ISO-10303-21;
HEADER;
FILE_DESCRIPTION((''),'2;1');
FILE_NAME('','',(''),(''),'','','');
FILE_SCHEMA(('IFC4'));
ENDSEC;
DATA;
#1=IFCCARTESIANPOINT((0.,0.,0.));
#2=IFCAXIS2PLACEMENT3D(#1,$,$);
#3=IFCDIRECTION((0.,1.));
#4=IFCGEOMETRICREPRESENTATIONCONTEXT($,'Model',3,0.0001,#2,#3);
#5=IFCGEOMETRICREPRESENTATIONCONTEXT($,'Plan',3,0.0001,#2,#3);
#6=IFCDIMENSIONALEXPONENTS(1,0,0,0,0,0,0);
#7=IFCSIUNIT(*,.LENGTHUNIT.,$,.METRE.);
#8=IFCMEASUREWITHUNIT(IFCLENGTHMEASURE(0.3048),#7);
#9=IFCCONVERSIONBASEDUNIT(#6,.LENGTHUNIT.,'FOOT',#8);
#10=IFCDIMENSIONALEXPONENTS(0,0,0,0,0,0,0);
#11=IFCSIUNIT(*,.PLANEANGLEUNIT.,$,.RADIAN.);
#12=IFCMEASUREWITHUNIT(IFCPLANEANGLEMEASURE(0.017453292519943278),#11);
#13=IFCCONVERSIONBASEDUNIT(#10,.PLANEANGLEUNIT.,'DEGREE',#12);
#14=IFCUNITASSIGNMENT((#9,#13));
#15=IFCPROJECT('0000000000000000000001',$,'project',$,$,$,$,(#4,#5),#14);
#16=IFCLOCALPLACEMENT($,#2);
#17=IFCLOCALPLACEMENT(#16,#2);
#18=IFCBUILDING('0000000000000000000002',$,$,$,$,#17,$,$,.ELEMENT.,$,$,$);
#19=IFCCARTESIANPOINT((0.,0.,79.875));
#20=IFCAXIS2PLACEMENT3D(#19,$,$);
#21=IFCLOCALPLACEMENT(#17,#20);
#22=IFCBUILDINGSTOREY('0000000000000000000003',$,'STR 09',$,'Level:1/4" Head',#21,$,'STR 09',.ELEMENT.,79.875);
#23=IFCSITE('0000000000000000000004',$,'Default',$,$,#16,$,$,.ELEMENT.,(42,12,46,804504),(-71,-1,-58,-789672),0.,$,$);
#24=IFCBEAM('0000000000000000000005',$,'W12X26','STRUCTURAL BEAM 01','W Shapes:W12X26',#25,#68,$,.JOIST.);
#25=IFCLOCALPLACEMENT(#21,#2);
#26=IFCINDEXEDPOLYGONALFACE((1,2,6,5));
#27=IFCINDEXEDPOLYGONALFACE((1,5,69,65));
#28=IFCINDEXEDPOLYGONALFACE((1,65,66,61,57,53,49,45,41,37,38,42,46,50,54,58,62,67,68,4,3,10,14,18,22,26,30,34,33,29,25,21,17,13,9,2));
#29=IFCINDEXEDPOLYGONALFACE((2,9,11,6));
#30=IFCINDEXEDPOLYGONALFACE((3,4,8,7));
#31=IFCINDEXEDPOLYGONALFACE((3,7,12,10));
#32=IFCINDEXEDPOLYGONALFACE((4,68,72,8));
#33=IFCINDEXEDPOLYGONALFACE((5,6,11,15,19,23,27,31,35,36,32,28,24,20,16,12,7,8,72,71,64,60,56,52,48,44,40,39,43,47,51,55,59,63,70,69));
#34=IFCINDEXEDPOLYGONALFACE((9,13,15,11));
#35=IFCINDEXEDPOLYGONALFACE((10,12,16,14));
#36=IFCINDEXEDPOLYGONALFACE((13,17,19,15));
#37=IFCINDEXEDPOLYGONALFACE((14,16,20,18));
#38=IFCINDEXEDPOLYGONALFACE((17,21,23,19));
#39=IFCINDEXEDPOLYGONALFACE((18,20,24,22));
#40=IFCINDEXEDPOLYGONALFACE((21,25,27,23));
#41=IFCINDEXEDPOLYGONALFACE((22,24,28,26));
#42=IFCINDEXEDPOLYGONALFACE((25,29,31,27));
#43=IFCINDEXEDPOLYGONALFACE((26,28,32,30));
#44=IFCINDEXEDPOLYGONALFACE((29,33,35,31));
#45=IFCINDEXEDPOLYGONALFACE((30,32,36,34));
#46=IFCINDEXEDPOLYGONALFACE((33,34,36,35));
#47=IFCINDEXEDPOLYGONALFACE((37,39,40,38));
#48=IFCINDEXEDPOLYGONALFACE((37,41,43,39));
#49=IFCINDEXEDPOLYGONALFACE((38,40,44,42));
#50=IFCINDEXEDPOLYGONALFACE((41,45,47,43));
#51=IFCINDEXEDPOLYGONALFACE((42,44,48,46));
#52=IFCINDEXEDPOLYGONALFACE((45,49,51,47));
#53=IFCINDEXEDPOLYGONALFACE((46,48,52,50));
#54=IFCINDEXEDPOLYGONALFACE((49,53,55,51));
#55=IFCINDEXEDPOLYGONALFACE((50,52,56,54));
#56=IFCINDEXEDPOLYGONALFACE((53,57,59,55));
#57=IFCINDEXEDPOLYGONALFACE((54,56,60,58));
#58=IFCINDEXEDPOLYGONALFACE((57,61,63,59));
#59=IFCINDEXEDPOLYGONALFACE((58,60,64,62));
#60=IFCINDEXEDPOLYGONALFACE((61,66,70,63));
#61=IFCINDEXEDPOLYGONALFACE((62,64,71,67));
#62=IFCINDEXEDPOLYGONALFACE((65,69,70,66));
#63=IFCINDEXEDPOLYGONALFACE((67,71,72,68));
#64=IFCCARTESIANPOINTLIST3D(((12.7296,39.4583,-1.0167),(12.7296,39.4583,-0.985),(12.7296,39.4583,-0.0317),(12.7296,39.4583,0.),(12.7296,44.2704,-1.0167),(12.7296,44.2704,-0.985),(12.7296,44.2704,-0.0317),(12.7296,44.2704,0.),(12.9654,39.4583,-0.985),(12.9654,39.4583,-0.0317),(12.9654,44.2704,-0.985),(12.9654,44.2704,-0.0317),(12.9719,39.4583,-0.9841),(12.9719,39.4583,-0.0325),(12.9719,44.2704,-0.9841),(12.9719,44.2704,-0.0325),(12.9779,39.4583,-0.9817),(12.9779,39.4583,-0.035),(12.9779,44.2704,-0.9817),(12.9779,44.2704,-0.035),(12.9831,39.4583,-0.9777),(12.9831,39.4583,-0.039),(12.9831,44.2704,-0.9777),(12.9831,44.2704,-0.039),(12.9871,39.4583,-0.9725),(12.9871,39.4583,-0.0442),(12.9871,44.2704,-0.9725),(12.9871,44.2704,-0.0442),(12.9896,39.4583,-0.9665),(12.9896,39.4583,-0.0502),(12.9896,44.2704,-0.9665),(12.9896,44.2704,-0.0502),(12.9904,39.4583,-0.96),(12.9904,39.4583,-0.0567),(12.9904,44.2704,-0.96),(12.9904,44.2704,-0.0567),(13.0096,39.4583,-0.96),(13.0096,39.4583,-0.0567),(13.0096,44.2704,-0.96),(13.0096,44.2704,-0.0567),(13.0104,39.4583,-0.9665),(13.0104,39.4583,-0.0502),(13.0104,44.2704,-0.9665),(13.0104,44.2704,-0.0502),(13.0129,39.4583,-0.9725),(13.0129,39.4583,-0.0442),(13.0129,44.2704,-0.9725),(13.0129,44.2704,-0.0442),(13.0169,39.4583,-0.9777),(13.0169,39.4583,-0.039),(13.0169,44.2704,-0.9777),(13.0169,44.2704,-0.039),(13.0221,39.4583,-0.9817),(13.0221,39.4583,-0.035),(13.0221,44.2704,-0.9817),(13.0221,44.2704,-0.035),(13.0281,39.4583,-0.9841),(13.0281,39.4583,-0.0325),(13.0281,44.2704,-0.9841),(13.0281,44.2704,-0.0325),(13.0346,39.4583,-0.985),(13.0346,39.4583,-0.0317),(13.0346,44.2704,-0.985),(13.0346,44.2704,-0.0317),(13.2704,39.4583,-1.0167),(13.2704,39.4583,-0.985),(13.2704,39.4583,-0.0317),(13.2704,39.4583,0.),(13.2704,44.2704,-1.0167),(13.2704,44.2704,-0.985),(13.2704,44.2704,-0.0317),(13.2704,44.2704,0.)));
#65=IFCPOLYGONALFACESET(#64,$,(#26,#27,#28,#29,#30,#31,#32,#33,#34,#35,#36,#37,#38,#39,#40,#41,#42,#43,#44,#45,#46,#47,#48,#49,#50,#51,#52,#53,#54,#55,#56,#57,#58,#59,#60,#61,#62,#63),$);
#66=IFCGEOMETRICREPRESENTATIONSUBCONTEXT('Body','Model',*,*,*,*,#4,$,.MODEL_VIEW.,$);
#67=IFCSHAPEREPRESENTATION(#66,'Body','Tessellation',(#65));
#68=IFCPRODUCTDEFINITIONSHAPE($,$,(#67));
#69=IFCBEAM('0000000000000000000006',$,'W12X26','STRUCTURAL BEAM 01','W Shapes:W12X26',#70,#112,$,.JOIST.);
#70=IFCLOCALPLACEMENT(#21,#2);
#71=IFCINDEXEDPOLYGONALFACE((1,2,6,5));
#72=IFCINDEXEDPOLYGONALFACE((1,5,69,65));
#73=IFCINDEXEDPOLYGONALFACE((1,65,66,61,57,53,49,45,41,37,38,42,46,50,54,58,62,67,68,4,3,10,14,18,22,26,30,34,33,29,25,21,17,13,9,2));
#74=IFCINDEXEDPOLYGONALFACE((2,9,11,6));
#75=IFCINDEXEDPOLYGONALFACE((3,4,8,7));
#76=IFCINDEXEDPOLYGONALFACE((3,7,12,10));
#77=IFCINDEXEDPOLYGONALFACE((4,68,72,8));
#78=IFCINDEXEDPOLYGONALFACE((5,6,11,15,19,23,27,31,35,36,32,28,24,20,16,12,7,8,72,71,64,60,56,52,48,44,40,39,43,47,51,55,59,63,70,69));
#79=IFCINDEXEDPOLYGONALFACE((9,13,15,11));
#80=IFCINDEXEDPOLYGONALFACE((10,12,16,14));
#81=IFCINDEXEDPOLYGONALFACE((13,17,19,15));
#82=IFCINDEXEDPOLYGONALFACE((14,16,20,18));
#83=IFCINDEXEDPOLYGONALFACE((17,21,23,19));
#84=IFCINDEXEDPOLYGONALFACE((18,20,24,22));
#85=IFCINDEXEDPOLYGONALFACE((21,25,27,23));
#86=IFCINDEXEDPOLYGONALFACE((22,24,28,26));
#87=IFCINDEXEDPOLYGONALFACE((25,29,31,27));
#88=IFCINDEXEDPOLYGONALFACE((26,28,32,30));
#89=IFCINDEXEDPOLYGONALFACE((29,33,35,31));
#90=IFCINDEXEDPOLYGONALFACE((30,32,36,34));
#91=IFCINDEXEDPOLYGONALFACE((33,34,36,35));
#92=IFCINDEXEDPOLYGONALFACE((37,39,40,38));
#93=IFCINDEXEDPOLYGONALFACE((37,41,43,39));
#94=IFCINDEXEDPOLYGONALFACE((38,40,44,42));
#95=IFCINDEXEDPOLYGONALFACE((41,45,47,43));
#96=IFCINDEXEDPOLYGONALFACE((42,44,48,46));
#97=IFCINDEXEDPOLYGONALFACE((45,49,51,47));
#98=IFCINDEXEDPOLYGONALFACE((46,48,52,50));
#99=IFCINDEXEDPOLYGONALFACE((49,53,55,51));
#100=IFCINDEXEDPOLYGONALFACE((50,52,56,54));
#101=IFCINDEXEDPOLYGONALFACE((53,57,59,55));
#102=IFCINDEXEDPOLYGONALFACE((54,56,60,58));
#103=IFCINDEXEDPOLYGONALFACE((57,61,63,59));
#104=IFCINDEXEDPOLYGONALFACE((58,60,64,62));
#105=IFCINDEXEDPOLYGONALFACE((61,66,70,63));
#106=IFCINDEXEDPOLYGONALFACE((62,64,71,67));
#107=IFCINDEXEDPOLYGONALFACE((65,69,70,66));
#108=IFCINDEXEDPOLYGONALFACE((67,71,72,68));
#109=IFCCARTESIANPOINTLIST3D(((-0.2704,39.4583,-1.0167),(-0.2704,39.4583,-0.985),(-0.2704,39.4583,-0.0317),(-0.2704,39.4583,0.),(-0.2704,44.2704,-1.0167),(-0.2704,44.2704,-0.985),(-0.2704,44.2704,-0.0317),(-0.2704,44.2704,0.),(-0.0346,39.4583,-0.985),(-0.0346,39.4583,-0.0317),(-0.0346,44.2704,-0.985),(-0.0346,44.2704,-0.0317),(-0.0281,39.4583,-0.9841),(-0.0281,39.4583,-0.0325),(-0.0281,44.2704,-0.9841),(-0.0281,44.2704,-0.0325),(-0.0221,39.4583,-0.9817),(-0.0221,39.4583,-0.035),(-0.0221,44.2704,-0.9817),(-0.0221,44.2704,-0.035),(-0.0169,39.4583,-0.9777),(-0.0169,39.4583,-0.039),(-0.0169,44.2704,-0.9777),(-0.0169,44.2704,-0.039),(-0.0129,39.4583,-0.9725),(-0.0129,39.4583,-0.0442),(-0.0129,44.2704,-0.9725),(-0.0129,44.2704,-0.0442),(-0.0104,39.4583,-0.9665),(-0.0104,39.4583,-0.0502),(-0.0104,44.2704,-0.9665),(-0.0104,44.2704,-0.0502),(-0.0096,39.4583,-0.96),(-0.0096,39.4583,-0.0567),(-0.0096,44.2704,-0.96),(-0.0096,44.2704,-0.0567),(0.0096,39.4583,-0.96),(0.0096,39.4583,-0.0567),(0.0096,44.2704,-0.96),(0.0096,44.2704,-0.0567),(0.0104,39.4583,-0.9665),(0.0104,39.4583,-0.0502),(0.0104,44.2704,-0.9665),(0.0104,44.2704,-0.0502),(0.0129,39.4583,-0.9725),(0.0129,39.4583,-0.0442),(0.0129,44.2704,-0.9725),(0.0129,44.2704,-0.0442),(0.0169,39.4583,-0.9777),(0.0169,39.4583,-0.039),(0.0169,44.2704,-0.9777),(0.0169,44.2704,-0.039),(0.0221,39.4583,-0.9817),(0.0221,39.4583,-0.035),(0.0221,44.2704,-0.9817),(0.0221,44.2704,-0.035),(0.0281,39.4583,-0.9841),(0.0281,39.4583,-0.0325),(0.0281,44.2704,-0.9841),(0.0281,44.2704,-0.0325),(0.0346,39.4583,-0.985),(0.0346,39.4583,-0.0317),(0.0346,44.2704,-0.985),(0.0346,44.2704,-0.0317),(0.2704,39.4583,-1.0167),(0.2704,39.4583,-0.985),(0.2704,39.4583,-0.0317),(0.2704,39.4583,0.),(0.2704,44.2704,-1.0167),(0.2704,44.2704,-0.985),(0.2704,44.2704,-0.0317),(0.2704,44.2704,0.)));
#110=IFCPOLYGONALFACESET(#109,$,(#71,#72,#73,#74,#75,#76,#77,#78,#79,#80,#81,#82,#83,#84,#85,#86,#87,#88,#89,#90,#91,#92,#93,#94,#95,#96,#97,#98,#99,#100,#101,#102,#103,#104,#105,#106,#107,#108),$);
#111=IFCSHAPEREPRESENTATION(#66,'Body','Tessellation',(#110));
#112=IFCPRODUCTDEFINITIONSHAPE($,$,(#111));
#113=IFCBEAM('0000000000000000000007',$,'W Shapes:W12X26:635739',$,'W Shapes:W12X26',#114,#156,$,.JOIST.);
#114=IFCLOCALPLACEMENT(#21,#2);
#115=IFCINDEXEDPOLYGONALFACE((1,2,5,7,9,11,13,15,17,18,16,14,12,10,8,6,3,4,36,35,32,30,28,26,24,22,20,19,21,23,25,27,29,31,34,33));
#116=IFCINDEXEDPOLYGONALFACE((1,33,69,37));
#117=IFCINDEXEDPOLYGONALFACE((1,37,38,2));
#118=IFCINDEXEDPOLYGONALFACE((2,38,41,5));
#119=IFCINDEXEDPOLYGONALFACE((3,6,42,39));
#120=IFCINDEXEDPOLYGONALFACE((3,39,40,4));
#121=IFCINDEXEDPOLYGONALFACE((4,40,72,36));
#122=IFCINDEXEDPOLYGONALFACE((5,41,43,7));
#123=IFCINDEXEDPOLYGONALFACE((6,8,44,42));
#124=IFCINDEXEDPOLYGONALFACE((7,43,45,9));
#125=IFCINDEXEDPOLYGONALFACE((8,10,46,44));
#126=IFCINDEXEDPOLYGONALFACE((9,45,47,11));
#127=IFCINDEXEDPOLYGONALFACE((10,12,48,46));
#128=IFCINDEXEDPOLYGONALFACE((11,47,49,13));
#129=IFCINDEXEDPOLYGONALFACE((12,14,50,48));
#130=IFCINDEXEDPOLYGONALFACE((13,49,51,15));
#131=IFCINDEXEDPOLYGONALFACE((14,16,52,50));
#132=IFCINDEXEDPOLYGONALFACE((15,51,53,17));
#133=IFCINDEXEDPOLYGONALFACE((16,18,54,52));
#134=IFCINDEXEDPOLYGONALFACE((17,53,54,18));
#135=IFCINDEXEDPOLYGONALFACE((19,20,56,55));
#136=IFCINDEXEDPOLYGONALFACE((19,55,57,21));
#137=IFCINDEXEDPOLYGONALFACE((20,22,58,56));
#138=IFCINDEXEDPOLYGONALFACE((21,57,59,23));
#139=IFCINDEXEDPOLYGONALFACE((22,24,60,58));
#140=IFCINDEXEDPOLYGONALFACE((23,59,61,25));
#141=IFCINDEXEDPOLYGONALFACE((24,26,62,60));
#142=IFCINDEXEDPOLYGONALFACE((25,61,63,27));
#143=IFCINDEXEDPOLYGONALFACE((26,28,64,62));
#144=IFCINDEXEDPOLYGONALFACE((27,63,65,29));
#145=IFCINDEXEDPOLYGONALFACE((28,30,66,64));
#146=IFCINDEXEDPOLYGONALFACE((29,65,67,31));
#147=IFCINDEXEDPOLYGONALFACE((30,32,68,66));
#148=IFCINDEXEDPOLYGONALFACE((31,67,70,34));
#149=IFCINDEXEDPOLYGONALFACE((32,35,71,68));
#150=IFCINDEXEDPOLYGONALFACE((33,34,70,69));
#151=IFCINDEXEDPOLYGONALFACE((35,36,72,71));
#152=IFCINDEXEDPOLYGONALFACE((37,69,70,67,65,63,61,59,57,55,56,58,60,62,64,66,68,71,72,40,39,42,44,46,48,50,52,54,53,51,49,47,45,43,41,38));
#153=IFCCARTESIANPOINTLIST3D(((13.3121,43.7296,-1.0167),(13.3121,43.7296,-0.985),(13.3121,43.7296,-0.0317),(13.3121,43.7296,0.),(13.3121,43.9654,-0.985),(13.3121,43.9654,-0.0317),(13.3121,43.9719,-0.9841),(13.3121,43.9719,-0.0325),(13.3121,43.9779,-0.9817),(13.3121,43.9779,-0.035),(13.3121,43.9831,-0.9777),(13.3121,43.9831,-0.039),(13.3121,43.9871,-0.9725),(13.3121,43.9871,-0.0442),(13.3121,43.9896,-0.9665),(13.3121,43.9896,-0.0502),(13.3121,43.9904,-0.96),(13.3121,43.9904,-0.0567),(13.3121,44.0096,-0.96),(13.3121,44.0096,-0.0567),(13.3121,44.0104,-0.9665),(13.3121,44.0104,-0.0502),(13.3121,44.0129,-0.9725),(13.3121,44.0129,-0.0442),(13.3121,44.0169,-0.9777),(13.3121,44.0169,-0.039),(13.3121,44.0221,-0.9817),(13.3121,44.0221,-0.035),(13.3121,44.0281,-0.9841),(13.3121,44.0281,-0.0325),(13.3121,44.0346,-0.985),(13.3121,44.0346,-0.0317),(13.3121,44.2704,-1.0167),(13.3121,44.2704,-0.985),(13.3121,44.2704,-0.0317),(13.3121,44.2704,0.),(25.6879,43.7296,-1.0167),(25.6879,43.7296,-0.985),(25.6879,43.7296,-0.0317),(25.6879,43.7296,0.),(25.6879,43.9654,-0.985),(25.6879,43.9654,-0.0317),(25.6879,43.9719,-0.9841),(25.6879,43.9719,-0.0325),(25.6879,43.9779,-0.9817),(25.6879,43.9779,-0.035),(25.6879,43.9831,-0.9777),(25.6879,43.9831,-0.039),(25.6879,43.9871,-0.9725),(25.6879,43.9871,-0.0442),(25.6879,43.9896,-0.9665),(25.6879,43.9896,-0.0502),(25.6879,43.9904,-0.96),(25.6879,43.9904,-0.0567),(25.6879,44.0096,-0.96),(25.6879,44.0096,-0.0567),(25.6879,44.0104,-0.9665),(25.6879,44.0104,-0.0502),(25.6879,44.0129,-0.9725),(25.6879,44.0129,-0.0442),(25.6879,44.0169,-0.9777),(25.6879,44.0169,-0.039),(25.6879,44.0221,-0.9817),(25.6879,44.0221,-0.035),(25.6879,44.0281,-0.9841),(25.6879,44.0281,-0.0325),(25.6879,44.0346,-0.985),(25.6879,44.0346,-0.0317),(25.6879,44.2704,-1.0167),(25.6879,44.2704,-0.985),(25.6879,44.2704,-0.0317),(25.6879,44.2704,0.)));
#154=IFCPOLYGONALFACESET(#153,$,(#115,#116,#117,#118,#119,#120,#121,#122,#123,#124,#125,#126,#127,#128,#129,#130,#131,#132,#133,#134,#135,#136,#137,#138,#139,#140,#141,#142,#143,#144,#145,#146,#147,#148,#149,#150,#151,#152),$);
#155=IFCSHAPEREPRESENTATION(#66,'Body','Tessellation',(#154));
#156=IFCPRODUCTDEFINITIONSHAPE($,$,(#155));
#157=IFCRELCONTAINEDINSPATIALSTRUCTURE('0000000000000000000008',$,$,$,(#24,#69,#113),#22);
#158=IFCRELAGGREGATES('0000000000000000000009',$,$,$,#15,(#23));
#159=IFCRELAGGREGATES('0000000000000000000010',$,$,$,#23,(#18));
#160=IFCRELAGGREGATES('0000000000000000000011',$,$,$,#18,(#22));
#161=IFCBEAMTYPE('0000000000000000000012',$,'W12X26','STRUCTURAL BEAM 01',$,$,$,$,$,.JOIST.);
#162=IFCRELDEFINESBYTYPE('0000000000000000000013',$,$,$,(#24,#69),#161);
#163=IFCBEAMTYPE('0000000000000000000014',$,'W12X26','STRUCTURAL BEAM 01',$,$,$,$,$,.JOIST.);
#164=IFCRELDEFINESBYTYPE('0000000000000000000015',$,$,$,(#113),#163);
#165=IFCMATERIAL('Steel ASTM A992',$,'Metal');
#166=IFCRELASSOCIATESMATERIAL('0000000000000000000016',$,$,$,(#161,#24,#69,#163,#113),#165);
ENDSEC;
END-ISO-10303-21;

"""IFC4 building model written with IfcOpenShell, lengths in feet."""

from ifc_helpers import new_model, entity, si_unit, converted_unit, direction, frame, origin, place, context, subcontext, project, spatial, line, arc, indexed_curve, outline, extrude, source, transform, mapped, material, type_object, type_shapes, element, save


model = new_model("IFC4")

# Units and contexts
model_context = context("Model", 3, precision=0.0001, world=origin(), true_north=direction((0.0, 1.0)))
plan_context = context("Plan", 3, precision=0.0001, world=origin(), true_north=direction((0.0, 1.0)))
body_context = subcontext(model_context, "Body", "Model", "MODEL_VIEW")
ifc_project = project(units=[converted_unit("LENGTHUNIT", "FOOT", entity("IfcLengthMeasure", 0.3048), si_unit("LENGTHUNIT", "METRE"), dimensions=[1, 0, 0, 0, 0, 0, 0]), converted_unit("PLANEANGLEUNIT", "DEGREE", entity("IfcPlaneAngleMeasure", 0.017453292519943278), si_unit("PLANEANGLEUNIT", "RADIAN"), dimensions=[0, 0, 0, 0, 0, 0, 0])], contexts=[model_context, plan_context])

# Site, building, storey
site_placement = place(None, origin())
site = spatial("IfcSite", under=ifc_project, at=site_placement, Name="Default", CompositionType="ELEMENT", RefLatitude=(42, 12, 46, 804504), RefLongitude=(-71, -1, -58, -789672), RefElevation=0.0)
building_placement = place(site_placement, origin())
building = spatial("IfcBuilding", under=site, at=building_placement, CompositionType="ELEMENT")
storey_placement = place(building_placement, frame((0.0, 0.0, 79.875)))
storey = spatial("IfcBuildingStorey", under=building, at=storey_placement, Name="STR 09", ObjectType="Level:1/4\" Head", LongName="STR 09", CompositionType="ELEMENT", Elevation=79.875)

# Beams
ifc_material = material(Name="Steel ASTM A992", Category="Metal")
beam_type_1 = type_object("IfcBeamType", Name="W12X26", Description="STRUCTURAL BEAM 01", PredefinedType="JOIST", material=ifc_material)
shared_shape_1 = source(origin(), body_context, "Body", "SweptSolid", [
    extrude(outline(indexed_curve([(0.4767, -0.2704), (0.5083, -0.2704), (0.5083, 0.2704), (0.4767, 0.2704), (0.4767, 0.0346), (0.4693, 0.0169), (0.4517, 0.0096), (-0.4517, 0.0096), (-0.4693, 0.0169), (-0.4767, 0.0346), (-0.4767, 0.2704), (-0.5083, 0.2704), (-0.5083, -0.2704), (-0.4767, -0.2704), (-0.4767, -0.0346), (-0.4693, -0.0169), (-0.4517, -0.0096), (0.4517, -0.0096), (0.4693, -0.0169), (0.4767, -0.0346)], segments=[line(1, 2, 3, 4, 5), arc(5, 6, 7), line(7, 8), arc(8, 9, 10), line(10, 11, 12, 13, 14, 15), arc(15, 16, 17), line(17, 18), arc(18, 19, 20), line(20, 1)], self_intersect=False)), frame((-2.7704, 0.0, 0.0), z_axis=(1.0, 0.0, 0.0), x_axis=(0.0, 0.0, -1.0)), (0.0, 0.0, 1.0), 4.8121),
])
type_shapes(beam_type_1, [shared_shape_1])
for number, where, z_axis, x_axis, name in (
    (1, (13.0, 41.5, -0.5083), (0.0, 0.0, 1.0), (0.0, -1.0, 0.0), "W12X26"),
    (2, (0.0, 41.5, -0.5083), (0.0, 0.0, 1.0), (0.0, -1.0, 0.0), "W12X26"),
):
    element("IfcBeam", number, at=place(storey_placement, frame(where, z_axis=z_axis, x_axis=x_axis)), inside=storey, type_object=beam_type_1, material=ifc_material, Name=name, Description="STRUCTURAL BEAM 01", ObjectType="W Shapes:W12X26", PredefinedType="JOIST", context=body_context, shape_type="MappedRepresentation", body=[
        mapped(shared_shape_1, transform((0.0, 0.0, 0.0), scale=1.0)),
    ])
beam_type_2 = type_object("IfcBeamType", Name="W12X26", Description="STRUCTURAL BEAM 01", PredefinedType="JOIST", material=ifc_material)
shared_shape_2 = source(origin(), body_context, "Body", "SweptSolid", [
    extrude(outline(indexed_curve([(0.4767, -0.2704), (0.5083, -0.2704), (0.5083, 0.2704), (0.4767, 0.2704), (0.4767, 0.0346), (0.4693, 0.0169), (0.4517, 0.0096), (-0.4517, 0.0096), (-0.4693, 0.0169), (-0.4767, 0.0346), (-0.4767, 0.2704), (-0.5083, 0.2704), (-0.5083, -0.2704), (-0.4767, -0.2704), (-0.4767, -0.0346), (-0.4693, -0.0169), (-0.4517, -0.0096), (0.4517, -0.0096), (0.4693, -0.0169), (0.4767, -0.0346)], segments=[line(1, 2, 3, 4, 5), arc(5, 6, 7), line(7, 8), arc(8, 9, 10), line(10, 11, 12, 13, 14, 15), arc(15, 16, 17), line(17, 18), arc(18, 19, 20), line(20, 1)], self_intersect=False)), frame((-6.1879, 0.0, 0.0), z_axis=(1.0, 0.0, 0.0), x_axis=(0.0, 0.0, -1.0)), (0.0, 0.0, 1.0), 12.3758),
])
type_shapes(beam_type_2, [shared_shape_2])
beam_1_placement = place(storey_placement, frame((19.5, 44.0, -0.5083), z_axis=(0.0, 0.0, 1.0), x_axis=(-1.0, 0.0, 0.0)))
element("IfcBeam", 3, at=beam_1_placement, inside=storey, type_object=beam_type_2, material=ifc_material, Name="W Shapes:W12X26:635739", ObjectType="W Shapes:W12X26", PredefinedType="JOIST", context=body_context, shape_type="MappedRepresentation", body=[
    mapped(shared_shape_2, transform((0.0, 0.0, 0.0), scale=1.0)),
])

save(model, "model.ifc")
